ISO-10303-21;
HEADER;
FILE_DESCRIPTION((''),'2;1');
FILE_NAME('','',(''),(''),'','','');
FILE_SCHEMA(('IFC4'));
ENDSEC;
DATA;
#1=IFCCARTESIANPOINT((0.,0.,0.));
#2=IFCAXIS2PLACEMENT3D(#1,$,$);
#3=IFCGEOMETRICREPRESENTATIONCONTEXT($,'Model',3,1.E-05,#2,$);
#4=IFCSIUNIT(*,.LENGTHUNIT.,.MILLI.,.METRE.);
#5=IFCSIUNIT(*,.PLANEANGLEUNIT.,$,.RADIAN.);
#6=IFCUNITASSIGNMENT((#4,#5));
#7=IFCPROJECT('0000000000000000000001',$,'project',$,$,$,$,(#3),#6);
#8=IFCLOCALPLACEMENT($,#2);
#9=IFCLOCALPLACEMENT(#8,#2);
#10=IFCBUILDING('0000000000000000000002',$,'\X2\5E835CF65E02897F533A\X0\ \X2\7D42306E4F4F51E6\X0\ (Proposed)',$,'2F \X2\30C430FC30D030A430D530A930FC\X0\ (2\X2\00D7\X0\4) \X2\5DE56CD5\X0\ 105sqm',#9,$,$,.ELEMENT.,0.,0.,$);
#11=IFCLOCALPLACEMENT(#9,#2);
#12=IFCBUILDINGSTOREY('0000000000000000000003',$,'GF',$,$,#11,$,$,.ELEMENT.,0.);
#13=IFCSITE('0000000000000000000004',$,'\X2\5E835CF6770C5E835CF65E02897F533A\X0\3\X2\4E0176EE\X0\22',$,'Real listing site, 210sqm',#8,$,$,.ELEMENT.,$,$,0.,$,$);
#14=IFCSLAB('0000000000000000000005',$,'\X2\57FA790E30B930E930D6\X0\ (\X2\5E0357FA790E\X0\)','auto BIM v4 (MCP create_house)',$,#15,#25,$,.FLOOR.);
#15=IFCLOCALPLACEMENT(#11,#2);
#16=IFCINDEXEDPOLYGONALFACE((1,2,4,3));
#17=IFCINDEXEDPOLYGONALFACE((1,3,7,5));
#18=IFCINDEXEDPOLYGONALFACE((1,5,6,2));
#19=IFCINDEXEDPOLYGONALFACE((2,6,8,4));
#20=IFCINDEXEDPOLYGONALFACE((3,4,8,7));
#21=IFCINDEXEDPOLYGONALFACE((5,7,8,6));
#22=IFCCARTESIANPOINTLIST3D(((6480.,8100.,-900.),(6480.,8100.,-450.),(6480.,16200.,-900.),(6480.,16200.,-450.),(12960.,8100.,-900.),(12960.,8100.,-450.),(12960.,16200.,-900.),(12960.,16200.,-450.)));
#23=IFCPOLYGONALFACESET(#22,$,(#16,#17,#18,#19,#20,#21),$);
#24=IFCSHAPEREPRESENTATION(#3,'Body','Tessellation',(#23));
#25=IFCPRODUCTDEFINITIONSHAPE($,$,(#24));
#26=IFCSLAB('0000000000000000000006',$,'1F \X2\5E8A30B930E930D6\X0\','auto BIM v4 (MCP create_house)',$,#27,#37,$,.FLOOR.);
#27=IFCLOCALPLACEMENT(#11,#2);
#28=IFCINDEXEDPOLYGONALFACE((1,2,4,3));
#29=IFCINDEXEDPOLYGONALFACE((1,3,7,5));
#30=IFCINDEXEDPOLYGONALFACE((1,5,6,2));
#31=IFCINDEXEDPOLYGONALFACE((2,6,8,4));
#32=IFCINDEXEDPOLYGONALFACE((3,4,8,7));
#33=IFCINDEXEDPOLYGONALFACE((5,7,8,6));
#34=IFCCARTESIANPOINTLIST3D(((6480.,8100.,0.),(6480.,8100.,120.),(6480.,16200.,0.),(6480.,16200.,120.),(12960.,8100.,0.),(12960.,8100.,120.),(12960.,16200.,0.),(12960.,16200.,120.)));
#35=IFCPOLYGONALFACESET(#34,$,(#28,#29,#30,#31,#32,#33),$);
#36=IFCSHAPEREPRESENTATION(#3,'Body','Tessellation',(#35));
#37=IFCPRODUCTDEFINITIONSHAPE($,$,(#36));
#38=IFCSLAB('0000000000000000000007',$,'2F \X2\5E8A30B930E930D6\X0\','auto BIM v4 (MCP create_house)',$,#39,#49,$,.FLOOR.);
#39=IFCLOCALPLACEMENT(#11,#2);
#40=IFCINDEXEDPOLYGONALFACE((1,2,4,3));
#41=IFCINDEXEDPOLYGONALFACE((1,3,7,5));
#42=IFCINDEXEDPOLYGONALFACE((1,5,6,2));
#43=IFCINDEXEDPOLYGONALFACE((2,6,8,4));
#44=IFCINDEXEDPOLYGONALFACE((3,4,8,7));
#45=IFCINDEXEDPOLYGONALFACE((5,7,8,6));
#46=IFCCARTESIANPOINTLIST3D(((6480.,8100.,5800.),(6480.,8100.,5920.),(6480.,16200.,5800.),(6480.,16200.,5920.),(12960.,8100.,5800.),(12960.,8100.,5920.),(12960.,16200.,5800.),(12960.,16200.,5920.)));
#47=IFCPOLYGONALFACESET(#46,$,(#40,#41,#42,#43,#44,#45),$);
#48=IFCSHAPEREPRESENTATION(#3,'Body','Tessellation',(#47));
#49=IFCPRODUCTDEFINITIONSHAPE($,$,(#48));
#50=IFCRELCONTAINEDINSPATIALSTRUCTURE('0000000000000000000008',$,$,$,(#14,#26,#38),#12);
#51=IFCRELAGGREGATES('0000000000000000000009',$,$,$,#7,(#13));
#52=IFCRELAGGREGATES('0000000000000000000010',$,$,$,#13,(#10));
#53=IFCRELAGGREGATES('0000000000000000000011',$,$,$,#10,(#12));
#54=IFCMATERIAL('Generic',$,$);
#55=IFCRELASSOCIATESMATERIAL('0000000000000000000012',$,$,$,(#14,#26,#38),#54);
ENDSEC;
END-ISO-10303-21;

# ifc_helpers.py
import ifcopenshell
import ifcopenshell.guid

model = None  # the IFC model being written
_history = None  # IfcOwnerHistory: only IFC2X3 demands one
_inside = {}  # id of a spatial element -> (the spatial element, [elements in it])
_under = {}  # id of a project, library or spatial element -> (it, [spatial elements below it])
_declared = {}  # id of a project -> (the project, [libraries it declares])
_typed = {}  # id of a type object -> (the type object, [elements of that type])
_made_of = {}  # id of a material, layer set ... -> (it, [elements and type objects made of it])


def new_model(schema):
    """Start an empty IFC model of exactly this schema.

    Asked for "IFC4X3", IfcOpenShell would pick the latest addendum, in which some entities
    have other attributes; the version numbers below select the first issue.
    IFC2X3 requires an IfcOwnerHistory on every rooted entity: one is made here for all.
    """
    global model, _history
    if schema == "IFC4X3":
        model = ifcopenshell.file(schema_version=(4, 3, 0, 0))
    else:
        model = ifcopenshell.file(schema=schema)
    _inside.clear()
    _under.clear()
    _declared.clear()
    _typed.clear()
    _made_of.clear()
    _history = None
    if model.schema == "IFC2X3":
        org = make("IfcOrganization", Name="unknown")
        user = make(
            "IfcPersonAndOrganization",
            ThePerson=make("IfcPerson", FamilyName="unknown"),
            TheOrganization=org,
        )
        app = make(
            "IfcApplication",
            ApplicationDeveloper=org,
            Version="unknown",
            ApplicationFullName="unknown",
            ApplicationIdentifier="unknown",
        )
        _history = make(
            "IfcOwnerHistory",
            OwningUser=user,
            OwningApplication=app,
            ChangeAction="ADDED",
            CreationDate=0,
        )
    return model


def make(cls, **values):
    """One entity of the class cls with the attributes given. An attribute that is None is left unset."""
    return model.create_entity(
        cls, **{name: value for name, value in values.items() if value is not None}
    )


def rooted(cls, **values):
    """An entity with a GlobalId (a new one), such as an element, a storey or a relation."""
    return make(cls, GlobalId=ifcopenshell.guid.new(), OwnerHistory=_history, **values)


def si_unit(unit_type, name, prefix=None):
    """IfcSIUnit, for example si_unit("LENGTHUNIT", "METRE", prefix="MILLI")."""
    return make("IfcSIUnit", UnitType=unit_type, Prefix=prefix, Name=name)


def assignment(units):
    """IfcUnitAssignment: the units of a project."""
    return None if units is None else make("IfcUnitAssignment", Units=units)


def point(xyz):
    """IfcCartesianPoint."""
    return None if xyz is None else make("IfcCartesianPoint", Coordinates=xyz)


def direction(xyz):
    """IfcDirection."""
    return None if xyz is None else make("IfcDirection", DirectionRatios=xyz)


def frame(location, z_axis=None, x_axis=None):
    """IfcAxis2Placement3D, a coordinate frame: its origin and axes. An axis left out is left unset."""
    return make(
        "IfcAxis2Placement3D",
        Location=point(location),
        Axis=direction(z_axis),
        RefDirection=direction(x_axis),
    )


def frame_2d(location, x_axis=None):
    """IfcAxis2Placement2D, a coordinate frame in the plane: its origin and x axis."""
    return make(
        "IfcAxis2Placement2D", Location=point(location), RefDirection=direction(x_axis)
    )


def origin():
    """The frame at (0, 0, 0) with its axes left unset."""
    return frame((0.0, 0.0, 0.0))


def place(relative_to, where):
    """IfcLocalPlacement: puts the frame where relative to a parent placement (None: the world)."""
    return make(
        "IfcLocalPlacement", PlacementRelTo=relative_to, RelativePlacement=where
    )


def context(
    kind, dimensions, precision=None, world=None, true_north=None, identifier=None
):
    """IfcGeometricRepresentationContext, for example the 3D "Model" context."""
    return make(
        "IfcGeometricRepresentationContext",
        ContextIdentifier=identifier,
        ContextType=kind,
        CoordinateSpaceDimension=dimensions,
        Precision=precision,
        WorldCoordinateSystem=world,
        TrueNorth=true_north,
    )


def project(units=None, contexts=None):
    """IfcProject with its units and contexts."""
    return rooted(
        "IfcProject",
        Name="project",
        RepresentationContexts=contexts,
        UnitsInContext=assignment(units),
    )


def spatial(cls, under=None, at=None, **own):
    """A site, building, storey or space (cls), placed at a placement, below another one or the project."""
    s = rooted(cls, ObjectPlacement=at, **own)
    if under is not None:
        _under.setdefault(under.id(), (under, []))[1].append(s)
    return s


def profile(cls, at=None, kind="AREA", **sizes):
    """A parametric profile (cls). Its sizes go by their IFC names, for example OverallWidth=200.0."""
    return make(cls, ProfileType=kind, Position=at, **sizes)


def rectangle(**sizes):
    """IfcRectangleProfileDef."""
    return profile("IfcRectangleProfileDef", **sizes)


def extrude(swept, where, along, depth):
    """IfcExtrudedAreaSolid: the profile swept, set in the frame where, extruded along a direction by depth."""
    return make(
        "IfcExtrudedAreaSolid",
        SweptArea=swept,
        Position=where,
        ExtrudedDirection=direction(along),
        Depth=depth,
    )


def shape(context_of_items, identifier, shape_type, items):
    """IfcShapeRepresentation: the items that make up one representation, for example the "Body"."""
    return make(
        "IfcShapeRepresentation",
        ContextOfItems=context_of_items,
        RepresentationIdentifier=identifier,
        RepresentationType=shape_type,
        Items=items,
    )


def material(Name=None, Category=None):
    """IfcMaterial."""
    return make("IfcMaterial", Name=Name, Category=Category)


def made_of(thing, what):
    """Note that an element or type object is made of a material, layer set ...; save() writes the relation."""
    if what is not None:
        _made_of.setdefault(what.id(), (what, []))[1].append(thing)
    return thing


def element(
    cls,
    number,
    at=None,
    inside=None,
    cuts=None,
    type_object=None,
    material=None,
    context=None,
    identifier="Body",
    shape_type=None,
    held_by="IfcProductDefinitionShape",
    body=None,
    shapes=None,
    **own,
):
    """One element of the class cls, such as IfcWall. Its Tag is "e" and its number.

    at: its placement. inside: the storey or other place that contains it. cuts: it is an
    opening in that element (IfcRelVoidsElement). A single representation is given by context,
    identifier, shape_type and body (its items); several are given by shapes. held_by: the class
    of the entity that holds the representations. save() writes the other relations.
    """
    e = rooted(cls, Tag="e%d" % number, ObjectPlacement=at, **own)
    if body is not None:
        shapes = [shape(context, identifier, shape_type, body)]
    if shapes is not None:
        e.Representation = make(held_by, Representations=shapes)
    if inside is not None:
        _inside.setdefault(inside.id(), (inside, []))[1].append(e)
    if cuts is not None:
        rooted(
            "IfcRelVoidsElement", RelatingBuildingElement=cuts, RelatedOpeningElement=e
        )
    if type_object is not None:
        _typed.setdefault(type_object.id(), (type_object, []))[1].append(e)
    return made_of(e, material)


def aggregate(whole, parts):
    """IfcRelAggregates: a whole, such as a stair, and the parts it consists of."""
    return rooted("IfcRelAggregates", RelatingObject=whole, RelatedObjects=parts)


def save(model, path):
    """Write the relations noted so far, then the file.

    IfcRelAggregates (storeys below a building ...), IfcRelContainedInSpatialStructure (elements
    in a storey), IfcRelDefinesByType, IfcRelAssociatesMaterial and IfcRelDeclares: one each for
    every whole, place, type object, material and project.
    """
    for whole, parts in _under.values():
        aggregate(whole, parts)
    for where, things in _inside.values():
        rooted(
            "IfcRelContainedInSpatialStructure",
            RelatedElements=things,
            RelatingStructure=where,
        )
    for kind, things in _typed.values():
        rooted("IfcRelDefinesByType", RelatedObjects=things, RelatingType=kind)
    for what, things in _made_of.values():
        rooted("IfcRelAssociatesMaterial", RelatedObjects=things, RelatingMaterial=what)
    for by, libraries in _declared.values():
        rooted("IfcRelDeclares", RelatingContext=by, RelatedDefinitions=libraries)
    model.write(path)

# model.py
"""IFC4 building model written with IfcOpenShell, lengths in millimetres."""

from ifc_helpers import new_model, si_unit, frame, frame_2d, origin, place, context, project, spatial, rectangle, extrude, material, element, save


model = new_model("IFC4")

# Units and contexts
model_context = context("Model", 3, precision=1e-05, world=origin())
ifc_project = project(units=[si_unit("LENGTHUNIT", "METRE", prefix="MILLI"), si_unit("PLANEANGLEUNIT", "RADIAN")], contexts=[model_context])

# Site, building, storey
site_placement = place(None, origin())
site = spatial("IfcSite", under=ifc_project, at=site_placement, Name="広島県広島市西区3丁目22", ObjectType="Real listing site, 210sqm", CompositionType="ELEMENT", RefElevation=0.0)
building_placement = place(site_placement, origin())
building = spatial("IfcBuilding", under=site, at=building_placement, Name="広島市西区 終の住処 (Proposed)", ObjectType="2F ツーバイフォー (2×4) 工法 105sqm", CompositionType="ELEMENT", ElevationOfRefHeight=0.0, ElevationOfTerrain=0.0)
storey_placement = place(building_placement, origin())
storey = spatial("IfcBuildingStorey", under=building, at=storey_placement, Name="GF", CompositionType="ELEMENT", Elevation=0.0)

# Slabs
ifc_material = material(Name="Generic")
slab_1_placement = place(storey_placement, frame((3240.0, 4050.0, -450.0)))
element("IfcSlab", 1, at=slab_1_placement, inside=storey, material=ifc_material, Name="基礎スラブ (布基礎)", Description="auto BIM v4 (MCP create_house)", PredefinedType="FLOOR", context=model_context, shape_type="SweptSolid", body=[
    extrude(rectangle(XDim=6480.0, YDim=8100.0, at=frame_2d((3240.0, 4050.0))), frame((3240.0, 4050.0, -450.0)), (0.0, 0.0, 1.0), 450.0),
])
slab_2_placement = place(storey_placement, frame((3240.0, 4050.0, 0.0)))
element("IfcSlab", 2, at=slab_2_placement, inside=storey, material=ifc_material, Name="1F 床スラブ", Description="auto BIM v4 (MCP create_house)", PredefinedType="FLOOR", context=model_context, shape_type="SweptSolid", body=[
    extrude(rectangle(XDim=6480.0, YDim=8100.0, at=frame_2d((3240.0, 4050.0))), frame((3240.0, 4050.0, 0.0)), (0.0, 0.0, 1.0), 120.0),
])
slab_3_placement = place(storey_placement, frame((3240.0, 4050.0, 2900.0)))
element("IfcSlab", 3, at=slab_3_placement, inside=storey, material=ifc_material, Name="2F 床スラブ", Description="auto BIM v4 (MCP create_house)", PredefinedType="FLOOR", context=model_context, shape_type="SweptSolid", body=[
    extrude(rectangle(XDim=6480.0, YDim=8100.0, at=frame_2d((3240.0, 4050.0))), frame((3240.0, 4050.0, 2900.0)), (0.0, 0.0, 1.0), 120.0),
])

save(model, "model.ifc")
